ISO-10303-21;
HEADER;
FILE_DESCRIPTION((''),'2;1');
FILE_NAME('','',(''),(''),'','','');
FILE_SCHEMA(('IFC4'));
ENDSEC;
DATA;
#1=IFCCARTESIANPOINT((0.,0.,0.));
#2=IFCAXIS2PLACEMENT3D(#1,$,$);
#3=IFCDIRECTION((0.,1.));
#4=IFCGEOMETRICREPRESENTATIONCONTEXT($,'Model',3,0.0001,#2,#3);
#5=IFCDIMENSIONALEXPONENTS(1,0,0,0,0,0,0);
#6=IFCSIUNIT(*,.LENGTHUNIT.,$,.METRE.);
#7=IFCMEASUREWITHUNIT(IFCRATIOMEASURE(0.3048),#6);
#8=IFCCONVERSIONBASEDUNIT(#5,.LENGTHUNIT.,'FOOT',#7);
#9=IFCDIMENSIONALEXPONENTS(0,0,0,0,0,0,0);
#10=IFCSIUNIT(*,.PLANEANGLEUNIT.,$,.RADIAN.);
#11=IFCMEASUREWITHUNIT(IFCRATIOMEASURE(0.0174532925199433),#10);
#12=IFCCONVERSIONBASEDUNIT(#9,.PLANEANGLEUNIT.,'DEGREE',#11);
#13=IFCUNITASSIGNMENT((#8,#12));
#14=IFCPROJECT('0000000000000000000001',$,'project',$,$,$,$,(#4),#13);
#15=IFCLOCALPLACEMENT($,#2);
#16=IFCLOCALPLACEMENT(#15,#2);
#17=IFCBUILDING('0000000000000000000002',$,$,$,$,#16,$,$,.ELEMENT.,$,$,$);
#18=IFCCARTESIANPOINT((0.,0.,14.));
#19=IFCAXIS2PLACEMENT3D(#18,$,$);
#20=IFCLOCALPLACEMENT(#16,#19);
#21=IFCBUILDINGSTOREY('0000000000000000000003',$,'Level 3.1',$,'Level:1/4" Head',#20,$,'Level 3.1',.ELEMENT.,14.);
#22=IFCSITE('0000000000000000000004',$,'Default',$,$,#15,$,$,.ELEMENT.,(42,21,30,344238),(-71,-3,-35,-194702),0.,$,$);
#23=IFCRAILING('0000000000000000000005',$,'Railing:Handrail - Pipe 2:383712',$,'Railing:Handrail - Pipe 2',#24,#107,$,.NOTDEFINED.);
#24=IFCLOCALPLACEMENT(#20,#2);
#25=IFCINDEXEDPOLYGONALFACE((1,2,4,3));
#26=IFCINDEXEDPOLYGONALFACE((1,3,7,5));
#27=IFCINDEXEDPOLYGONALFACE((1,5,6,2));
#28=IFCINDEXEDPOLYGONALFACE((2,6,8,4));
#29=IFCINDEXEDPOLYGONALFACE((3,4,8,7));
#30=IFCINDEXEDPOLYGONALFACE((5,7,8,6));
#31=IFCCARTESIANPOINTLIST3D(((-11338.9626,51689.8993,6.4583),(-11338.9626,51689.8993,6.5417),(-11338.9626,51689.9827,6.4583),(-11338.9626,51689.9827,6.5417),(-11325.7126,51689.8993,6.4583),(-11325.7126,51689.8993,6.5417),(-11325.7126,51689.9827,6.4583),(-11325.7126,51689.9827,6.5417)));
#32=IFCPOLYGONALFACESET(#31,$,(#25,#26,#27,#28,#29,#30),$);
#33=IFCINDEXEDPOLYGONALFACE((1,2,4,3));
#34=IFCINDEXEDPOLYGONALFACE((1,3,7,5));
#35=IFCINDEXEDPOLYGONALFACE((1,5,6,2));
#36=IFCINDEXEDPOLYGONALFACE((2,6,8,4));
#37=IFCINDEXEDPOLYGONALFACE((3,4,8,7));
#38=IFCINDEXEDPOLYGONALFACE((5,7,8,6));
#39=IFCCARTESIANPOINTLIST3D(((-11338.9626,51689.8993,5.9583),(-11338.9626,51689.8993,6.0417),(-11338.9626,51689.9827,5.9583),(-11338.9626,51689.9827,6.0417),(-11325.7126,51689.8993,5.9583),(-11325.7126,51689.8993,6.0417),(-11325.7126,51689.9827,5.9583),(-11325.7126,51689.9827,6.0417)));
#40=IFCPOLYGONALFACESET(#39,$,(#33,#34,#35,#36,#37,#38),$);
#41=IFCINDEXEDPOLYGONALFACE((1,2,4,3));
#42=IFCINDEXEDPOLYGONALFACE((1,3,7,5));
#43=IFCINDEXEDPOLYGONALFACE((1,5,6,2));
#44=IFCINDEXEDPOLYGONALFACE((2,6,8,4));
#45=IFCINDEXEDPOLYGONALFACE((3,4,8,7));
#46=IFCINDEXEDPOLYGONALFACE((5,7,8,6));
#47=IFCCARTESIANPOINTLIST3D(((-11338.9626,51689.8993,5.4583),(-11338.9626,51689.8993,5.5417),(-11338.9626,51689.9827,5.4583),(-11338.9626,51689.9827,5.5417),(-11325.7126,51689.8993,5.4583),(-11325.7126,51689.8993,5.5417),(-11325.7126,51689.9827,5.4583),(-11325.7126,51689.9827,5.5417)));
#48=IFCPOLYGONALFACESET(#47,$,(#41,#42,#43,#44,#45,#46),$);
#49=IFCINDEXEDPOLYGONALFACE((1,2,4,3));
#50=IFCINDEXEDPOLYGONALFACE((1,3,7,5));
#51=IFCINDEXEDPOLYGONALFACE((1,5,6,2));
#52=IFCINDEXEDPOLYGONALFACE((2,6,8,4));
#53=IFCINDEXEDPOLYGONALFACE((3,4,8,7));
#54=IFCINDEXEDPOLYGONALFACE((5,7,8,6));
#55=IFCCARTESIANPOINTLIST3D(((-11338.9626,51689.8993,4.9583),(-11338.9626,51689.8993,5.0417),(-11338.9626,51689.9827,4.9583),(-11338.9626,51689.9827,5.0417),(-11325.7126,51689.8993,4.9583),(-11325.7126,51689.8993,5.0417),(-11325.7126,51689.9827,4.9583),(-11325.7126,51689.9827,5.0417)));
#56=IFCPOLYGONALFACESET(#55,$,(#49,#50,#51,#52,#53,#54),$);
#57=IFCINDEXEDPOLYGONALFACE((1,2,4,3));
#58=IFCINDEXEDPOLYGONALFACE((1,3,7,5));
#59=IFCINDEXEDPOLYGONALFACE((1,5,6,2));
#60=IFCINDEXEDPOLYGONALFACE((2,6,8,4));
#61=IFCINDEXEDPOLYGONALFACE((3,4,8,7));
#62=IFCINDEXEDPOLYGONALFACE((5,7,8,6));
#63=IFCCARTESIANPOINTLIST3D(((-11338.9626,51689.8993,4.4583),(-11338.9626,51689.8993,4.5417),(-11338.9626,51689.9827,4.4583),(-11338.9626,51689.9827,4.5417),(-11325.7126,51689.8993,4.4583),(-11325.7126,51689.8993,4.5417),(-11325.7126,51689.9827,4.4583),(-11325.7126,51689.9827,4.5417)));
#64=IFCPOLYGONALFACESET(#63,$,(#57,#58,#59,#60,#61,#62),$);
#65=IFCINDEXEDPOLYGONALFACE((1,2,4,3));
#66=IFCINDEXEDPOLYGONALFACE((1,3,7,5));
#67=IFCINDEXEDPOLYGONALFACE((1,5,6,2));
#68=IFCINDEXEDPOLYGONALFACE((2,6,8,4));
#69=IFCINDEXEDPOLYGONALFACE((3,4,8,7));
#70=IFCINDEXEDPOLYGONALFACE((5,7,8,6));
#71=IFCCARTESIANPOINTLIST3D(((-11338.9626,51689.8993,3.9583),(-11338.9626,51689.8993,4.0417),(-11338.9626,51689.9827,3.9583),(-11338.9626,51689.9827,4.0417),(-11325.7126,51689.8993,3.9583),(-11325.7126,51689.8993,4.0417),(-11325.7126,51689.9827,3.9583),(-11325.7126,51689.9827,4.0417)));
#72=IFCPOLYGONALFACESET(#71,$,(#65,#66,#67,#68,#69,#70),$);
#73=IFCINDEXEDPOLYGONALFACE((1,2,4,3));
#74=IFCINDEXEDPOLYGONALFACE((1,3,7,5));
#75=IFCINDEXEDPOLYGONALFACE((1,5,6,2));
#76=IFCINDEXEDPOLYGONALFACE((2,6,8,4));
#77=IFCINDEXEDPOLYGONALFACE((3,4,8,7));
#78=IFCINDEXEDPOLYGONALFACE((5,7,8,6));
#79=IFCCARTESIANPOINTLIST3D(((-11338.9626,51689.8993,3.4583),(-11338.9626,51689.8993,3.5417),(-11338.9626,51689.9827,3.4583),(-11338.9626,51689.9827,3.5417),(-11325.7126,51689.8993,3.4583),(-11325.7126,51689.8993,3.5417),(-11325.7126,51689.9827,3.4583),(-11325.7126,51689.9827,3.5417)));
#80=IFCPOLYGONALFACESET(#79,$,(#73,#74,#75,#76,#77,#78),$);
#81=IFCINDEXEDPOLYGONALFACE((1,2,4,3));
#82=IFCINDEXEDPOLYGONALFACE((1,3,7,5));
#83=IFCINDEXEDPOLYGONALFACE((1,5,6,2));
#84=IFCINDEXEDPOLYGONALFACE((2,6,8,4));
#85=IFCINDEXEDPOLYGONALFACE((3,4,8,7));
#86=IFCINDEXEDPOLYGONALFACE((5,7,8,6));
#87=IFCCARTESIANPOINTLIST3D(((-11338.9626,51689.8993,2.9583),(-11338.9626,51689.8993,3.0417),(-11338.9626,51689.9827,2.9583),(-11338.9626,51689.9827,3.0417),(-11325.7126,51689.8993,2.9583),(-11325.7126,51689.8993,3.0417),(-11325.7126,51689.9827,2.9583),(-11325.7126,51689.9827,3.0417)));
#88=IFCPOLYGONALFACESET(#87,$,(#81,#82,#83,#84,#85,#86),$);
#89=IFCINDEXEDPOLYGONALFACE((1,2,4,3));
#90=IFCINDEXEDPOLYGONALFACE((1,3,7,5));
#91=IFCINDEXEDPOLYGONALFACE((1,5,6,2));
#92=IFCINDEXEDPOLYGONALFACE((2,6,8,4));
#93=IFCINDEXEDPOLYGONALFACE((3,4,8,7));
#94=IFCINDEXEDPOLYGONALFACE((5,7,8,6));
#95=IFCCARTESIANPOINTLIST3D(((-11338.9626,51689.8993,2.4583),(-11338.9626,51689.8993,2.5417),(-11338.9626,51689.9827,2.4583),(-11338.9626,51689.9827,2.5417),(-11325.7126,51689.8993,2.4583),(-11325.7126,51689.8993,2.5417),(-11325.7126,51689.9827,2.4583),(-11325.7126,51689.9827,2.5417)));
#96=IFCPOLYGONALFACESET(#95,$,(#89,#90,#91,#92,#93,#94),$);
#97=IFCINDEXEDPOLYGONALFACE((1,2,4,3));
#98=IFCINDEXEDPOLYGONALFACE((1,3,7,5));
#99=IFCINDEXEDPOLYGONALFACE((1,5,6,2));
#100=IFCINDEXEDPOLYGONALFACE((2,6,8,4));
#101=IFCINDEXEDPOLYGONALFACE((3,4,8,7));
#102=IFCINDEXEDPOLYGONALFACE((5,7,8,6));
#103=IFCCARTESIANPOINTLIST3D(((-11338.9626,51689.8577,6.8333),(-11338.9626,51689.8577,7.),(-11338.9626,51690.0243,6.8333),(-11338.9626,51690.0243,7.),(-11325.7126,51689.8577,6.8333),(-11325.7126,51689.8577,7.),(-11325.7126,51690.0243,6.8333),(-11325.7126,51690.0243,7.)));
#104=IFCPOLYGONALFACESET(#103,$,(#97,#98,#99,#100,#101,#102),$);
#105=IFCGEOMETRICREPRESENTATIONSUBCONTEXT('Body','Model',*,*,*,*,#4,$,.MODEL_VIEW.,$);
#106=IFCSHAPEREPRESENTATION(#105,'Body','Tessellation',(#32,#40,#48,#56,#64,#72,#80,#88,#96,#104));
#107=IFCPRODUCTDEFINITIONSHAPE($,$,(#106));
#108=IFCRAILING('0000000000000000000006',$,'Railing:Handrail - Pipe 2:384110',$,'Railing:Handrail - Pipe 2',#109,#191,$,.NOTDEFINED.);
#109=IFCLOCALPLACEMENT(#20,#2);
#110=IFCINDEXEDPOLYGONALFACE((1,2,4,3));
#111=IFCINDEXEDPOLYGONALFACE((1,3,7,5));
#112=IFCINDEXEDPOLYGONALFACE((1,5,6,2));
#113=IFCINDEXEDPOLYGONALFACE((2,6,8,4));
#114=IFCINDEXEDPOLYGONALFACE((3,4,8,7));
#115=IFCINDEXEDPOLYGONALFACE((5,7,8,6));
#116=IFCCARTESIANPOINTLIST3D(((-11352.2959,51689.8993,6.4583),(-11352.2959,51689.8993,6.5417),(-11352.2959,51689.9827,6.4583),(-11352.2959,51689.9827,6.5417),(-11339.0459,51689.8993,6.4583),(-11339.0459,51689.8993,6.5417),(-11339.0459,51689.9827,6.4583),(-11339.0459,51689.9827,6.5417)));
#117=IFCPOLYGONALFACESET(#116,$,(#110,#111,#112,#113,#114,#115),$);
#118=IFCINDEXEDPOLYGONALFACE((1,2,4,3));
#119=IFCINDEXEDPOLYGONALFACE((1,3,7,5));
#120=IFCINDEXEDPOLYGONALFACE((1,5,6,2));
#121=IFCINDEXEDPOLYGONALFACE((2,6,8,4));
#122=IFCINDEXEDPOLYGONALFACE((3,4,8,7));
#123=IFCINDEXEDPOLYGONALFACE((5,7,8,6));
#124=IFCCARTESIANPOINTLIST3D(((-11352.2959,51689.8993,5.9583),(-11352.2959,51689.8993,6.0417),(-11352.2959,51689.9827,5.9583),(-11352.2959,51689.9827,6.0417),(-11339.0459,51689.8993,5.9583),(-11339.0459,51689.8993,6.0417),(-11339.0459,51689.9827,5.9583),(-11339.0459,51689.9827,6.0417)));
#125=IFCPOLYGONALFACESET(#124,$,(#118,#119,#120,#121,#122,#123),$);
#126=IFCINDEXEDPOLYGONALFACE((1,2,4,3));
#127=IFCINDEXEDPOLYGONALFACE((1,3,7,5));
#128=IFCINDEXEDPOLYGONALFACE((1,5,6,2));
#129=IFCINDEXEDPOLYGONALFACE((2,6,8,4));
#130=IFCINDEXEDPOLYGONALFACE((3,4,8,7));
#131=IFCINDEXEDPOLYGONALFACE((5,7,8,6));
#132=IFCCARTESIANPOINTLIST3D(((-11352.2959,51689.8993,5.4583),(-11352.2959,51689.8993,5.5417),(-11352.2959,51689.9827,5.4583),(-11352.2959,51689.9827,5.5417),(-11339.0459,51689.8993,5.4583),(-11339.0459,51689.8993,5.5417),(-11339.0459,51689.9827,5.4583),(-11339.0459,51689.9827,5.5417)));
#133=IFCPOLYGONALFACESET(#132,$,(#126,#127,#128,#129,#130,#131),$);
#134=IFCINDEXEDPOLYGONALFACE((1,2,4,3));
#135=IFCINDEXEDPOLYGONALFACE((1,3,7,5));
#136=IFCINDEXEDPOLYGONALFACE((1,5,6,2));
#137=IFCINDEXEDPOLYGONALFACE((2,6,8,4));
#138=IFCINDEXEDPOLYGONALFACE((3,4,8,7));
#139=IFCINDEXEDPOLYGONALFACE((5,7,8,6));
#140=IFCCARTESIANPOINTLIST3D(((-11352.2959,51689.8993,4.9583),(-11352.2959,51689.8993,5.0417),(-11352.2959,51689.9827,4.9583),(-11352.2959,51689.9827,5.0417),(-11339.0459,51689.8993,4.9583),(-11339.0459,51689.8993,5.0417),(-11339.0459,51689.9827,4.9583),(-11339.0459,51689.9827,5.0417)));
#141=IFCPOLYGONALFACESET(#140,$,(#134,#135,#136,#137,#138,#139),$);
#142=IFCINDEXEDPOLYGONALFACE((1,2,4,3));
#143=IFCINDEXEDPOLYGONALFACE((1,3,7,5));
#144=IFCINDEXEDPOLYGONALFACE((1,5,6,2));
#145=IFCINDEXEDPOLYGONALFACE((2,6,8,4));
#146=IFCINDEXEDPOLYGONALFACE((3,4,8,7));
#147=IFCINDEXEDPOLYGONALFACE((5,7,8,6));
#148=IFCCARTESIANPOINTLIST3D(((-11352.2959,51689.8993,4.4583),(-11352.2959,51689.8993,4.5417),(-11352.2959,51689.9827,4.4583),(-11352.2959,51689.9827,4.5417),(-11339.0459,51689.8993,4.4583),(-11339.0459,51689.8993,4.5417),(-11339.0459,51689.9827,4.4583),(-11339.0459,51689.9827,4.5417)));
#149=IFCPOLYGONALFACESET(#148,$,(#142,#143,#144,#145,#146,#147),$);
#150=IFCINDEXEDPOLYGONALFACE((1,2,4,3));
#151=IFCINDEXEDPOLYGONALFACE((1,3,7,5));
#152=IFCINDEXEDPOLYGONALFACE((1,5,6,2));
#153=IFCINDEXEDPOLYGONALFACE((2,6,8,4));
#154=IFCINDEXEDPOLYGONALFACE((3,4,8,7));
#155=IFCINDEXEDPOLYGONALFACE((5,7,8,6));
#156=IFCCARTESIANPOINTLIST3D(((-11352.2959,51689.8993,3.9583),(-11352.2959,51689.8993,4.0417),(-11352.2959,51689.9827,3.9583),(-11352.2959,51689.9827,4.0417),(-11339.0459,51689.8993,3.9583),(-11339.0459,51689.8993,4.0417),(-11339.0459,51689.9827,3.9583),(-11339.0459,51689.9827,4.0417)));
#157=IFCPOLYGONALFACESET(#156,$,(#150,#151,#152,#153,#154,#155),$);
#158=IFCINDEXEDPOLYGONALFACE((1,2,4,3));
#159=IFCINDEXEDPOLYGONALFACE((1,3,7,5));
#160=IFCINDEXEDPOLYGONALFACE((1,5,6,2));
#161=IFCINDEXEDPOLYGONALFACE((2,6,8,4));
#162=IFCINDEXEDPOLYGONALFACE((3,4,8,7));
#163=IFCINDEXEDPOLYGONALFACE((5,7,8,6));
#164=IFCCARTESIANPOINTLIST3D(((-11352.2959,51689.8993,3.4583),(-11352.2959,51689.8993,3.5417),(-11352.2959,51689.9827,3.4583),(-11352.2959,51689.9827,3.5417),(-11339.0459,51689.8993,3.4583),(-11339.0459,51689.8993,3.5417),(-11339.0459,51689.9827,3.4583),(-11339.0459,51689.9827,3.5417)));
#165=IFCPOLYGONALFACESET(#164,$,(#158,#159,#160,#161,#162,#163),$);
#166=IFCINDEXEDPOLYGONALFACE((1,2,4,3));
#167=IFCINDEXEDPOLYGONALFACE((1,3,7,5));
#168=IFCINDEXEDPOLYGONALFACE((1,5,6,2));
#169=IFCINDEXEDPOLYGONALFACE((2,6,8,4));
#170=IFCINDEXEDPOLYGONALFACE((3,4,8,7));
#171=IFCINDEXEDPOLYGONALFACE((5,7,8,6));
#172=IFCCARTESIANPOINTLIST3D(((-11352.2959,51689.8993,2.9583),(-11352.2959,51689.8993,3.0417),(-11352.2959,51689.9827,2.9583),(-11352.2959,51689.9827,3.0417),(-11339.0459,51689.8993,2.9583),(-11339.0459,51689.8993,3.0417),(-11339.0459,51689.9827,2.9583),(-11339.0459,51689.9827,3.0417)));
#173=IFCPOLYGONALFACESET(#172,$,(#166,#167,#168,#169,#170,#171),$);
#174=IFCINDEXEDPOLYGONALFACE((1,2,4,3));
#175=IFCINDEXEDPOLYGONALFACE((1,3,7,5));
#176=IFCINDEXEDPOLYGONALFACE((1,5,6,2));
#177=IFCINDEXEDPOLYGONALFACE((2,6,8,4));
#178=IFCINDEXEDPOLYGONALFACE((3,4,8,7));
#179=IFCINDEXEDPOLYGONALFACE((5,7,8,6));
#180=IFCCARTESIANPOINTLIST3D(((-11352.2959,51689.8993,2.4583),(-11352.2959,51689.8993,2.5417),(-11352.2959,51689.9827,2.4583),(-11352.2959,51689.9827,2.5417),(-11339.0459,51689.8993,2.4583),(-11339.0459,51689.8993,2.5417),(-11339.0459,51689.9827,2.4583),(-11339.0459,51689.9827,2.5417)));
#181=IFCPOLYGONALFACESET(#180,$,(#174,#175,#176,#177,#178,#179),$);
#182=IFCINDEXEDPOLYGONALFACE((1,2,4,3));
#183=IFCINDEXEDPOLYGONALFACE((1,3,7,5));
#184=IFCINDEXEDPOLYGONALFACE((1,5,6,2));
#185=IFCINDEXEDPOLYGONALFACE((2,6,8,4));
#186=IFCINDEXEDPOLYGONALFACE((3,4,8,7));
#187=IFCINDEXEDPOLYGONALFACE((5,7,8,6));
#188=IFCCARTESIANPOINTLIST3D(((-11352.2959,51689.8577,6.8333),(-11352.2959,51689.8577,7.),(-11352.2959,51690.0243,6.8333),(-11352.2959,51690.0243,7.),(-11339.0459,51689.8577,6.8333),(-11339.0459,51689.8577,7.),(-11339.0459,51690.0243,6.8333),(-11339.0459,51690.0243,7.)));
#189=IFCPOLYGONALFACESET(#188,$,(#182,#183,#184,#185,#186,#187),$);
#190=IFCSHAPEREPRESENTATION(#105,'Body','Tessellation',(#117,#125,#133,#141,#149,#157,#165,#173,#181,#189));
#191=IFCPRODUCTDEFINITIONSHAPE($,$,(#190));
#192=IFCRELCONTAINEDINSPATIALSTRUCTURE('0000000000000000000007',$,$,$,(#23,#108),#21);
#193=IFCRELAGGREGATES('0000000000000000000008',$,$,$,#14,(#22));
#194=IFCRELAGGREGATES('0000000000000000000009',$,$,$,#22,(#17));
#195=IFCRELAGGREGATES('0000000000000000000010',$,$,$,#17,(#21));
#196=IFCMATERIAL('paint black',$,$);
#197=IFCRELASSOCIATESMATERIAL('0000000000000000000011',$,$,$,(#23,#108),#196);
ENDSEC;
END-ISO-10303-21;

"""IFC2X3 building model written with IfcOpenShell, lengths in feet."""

from ifc_helpers import new_model, entity, si_unit, converted_unit, direction, frame, frame_2d, origin, place, context, subcontext, project, spatial, rectangle, extrude, material, element, save


model = new_model("IFC2X3")

# Units and contexts
model_context = context("Model", 3, precision=0.0001, world=origin(), true_north=direction((0.0, 1.0)))
body_context = subcontext(model_context, "Body", "Model", "MODEL_VIEW")
ifc_project = project(units=[converted_unit("LENGTHUNIT", "FOOT", entity("IfcRatioMeasure", 0.3048), si_unit("LENGTHUNIT", "METRE"), dimensions=[1, 0, 0, 0, 0, 0, 0]), converted_unit("PLANEANGLEUNIT", "DEGREE", entity("IfcRatioMeasure", 0.0174532925199433), si_unit("PLANEANGLEUNIT", "RADIAN"), dimensions=[0, 0, 0, 0, 0, 0, 0])], contexts=[model_context])

# Site, building, storey
site_placement = place(None, origin())
site = spatial("IfcSite", under=ifc_project, at=site_placement, Name="Default", CompositionType="ELEMENT", RefLatitude=(42, 21, 30, 344238), RefLongitude=(-71, -3, -35, -194702), RefElevation=0.0)
building_placement = place(site_placement, origin())
building = spatial("IfcBuilding", under=site, at=building_placement, CompositionType="ELEMENT")
storey_placement = place(building_placement, frame((0.0, 0.0, 14.0)))
storey = spatial("IfcBuildingStorey", under=building, at=storey_placement, Name="Level 3.1", ObjectType="Level:1/4\" Head", LongName="Level 3.1", CompositionType="ELEMENT", Elevation=14.0)

# Railings
ifc_material_1 = material(Name="paint black")
railing_1_placement = place(storey_placement, origin())
element("IfcRailing", 1, at=railing_1_placement, inside=storey, material=ifc_material_1, Name="Railing:Handrail - Pipe 2:383712", ObjectType="Railing:Handrail - Pipe 2", PredefinedType="NOTDEFINED", context=body_context, shape_type="SweptSolid", body=[
    extrude(rectangle(XDim=13.25, YDim=0.0833, at=frame_2d((0.0, 0.0), x_axis=(1.0, 0.0))), frame((-11332.3376, 51689.941, 6.4583), z_axis=(0.0, 0.0, 1.0), x_axis=(-1.0, 0.0, 0.0)), (0.0, 0.0, 1.0), 0.0833),
    extrude(rectangle(XDim=13.25, YDim=0.0833, at=frame_2d((0.0, 0.0), x_axis=(1.0, 0.0))), frame((-11332.3376, 51689.941, 5.9583), z_axis=(0.0, 0.0, 1.0), x_axis=(-1.0, 0.0, 0.0)), (0.0, 0.0, 1.0), 0.0833),
    extrude(rectangle(XDim=13.25, YDim=0.0833, at=frame_2d((0.0, 0.0), x_axis=(1.0, 0.0))), frame((-11332.3376, 51689.941, 5.4583), z_axis=(0.0, 0.0, 1.0), x_axis=(-1.0, 0.0, 0.0)), (0.0, 0.0, 1.0), 0.0833),
    extrude(rectangle(XDim=13.25, YDim=0.0833, at=frame_2d((0.0, 0.0), x_axis=(1.0, 0.0))), frame((-11332.3376, 51689.941, 4.9583), z_axis=(0.0, 0.0, 1.0), x_axis=(-1.0, 0.0, 0.0)), (0.0, 0.0, 1.0), 0.0833),
    extrude(rectangle(XDim=13.25, YDim=0.0833, at=frame_2d((0.0, 0.0), x_axis=(1.0, 0.0))), frame((-11332.3376, 51689.941, 4.4583), z_axis=(0.0, 0.0, 1.0), x_axis=(-1.0, 0.0, 0.0)), (0.0, 0.0, 1.0), 0.0833),
    extrude(rectangle(XDim=13.25, YDim=0.0833, at=frame_2d((0.0, 0.0), x_axis=(1.0, 0.0))), frame((-11332.3376, 51689.941, 3.9583), z_axis=(0.0, 0.0, 1.0), x_axis=(-1.0, 0.0, 0.0)), (0.0, 0.0, 1.0), 0.0833),
    extrude(rectangle(XDim=13.25, YDim=0.0833, at=frame_2d((0.0, 0.0), x_axis=(1.0, 0.0))), frame((-11332.3376, 51689.941, 3.4583), z_axis=(0.0, 0.0, 1.0), x_axis=(-1.0, 0.0, 0.0)), (0.0, 0.0, 1.0), 0.0833),
    extrude(rectangle(XDim=13.25, YDim=0.0833, at=frame_2d((0.0, 0.0), x_axis=(1.0, 0.0))), frame((-11332.3376, 51689.941, 2.9583), z_axis=(0.0, 0.0, 1.0), x_axis=(-1.0, 0.0, 0.0)), (0.0, 0.0, 1.0), 0.0833),
    extrude(rectangle(XDim=13.25, YDim=0.0833, at=frame_2d((0.0, 0.0), x_axis=(1.0, 0.0))), frame((-11332.3376, 51689.941, 2.4583), z_axis=(0.0, 0.0, 1.0), x_axis=(-1.0, 0.0, 0.0)), (0.0, 0.0, 1.0), 0.0833),
    extrude(rectangle(XDim=13.25, YDim=0.1667, at=frame_2d((0.0, 0.0), x_axis=(1.0, 0.0))), frame((-11332.3376, 51689.941, 6.8333), z_axis=(0.0, 0.0, 1.0), x_axis=(-1.0, 0.0, 0.0)), (0.0, 0.0, 1.0), 0.1667),
])
railing_2_placement = place(storey_placement, origin())
element("IfcRailing", 2, at=railing_2_placement, inside=storey, material=ifc_material_1, Name="Railing:Handrail - Pipe 2:384110", ObjectType="Railing:Handrail - Pipe 2", PredefinedType="NOTDEFINED", context=body_context, shape_type="SweptSolid", body=[
    extrude(rectangle(XDim=13.25, YDim=0.0833, at=frame_2d((0.0, 0.0), x_axis=(1.0, 0.0))), frame((-11345.6709, 51689.941, 6.4583), z_axis=(0.0, 0.0, 1.0), x_axis=(-1.0, 0.0, 0.0)), (0.0, 0.0, 1.0), 0.0833),
    extrude(rectangle(XDim=13.25, YDim=0.0833, at=frame_2d((0.0, 0.0), x_axis=(1.0, 0.0))), frame((-11345.6709, 51689.941, 5.9583), z_axis=(0.0, 0.0, 1.0), x_axis=(-1.0, 0.0, 0.0)), (0.0, 0.0, 1.0), 0.0833),
    extrude(rectangle(XDim=13.25, YDim=0.0833, at=frame_2d((0.0, 0.0), x_axis=(1.0, 0.0))), frame((-11345.6709, 51689.941, 5.4583), z_axis=(0.0, 0.0, 1.0), x_axis=(-1.0, 0.0, 0.0)), (0.0, 0.0, 1.0), 0.0833),
    extrude(rectangle(XDim=13.25, YDim=0.0833, at=frame_2d((0.0, 0.0), x_axis=(1.0, 0.0))), frame((-11345.6709, 51689.941, 4.9583), z_axis=(0.0, 0.0, 1.0), x_axis=(-1.0, 0.0, 0.0)), (0.0, 0.0, 1.0), 0.0833),
    extrude(rectangle(XDim=13.25, YDim=0.0833, at=frame_2d((0.0, 0.0), x_axis=(1.0, 0.0))), frame((-11345.6709, 51689.941, 4.4583), z_axis=(0.0, 0.0, 1.0), x_axis=(-1.0, 0.0, 0.0)), (0.0, 0.0, 1.0), 0.0833),
    extrude(rectangle(XDim=13.25, YDim=0.0833, at=frame_2d((0.0, 0.0), x_axis=(1.0, 0.0))), frame((-11345.6709, 51689.941, 3.9583), z_axis=(0.0, 0.0, 1.0), x_axis=(-1.0, 0.0, 0.0)), (0.0, 0.0, 1.0), 0.0833),
    extrude(rectangle(XDim=13.25, YDim=0.0833, at=frame_2d((0.0, 0.0), x_axis=(1.0, 0.0))), frame((-11345.6709, 51689.941, 3.4583), z_axis=(0.0, 0.0, 1.0), x_axis=(-1.0, 0.0, 0.0)), (0.0, 0.0, 1.0), 0.0833),
    extrude(rectangle(XDim=13.25, YDim=0.0833, at=frame_2d((0.0, 0.0), x_axis=(1.0, 0.0))), frame((-11345.6709, 51689.941, 2.9583), z_axis=(0.0, 0.0, 1.0), x_axis=(-1.0, 0.0, 0.0)), (0.0, 0.0, 1.0), 0.0833),
    extrude(rectangle(XDim=13.25, YDim=0.0833, at=frame_2d((0.0, 0.0), x_axis=(1.0, 0.0))), frame((-11345.6709, 51689.941, 2.4583), z_axis=(0.0, 0.0, 1.0), x_axis=(-1.0, 0.0, 0.0)), (0.0, 0.0, 1.0), 0.0833),
    extrude(rectangle(XDim=13.25, YDim=0.1667, at=frame_2d((0.0, 0.0), x_axis=(1.0, 0.0))), frame((-11345.6709, 51689.941, 6.8333), z_axis=(0.0, 0.0, 1.0), x_axis=(-1.0, 0.0, 0.0)), (0.0, 0.0, 1.0), 0.1667),
])

save(model, "model.ifc")
